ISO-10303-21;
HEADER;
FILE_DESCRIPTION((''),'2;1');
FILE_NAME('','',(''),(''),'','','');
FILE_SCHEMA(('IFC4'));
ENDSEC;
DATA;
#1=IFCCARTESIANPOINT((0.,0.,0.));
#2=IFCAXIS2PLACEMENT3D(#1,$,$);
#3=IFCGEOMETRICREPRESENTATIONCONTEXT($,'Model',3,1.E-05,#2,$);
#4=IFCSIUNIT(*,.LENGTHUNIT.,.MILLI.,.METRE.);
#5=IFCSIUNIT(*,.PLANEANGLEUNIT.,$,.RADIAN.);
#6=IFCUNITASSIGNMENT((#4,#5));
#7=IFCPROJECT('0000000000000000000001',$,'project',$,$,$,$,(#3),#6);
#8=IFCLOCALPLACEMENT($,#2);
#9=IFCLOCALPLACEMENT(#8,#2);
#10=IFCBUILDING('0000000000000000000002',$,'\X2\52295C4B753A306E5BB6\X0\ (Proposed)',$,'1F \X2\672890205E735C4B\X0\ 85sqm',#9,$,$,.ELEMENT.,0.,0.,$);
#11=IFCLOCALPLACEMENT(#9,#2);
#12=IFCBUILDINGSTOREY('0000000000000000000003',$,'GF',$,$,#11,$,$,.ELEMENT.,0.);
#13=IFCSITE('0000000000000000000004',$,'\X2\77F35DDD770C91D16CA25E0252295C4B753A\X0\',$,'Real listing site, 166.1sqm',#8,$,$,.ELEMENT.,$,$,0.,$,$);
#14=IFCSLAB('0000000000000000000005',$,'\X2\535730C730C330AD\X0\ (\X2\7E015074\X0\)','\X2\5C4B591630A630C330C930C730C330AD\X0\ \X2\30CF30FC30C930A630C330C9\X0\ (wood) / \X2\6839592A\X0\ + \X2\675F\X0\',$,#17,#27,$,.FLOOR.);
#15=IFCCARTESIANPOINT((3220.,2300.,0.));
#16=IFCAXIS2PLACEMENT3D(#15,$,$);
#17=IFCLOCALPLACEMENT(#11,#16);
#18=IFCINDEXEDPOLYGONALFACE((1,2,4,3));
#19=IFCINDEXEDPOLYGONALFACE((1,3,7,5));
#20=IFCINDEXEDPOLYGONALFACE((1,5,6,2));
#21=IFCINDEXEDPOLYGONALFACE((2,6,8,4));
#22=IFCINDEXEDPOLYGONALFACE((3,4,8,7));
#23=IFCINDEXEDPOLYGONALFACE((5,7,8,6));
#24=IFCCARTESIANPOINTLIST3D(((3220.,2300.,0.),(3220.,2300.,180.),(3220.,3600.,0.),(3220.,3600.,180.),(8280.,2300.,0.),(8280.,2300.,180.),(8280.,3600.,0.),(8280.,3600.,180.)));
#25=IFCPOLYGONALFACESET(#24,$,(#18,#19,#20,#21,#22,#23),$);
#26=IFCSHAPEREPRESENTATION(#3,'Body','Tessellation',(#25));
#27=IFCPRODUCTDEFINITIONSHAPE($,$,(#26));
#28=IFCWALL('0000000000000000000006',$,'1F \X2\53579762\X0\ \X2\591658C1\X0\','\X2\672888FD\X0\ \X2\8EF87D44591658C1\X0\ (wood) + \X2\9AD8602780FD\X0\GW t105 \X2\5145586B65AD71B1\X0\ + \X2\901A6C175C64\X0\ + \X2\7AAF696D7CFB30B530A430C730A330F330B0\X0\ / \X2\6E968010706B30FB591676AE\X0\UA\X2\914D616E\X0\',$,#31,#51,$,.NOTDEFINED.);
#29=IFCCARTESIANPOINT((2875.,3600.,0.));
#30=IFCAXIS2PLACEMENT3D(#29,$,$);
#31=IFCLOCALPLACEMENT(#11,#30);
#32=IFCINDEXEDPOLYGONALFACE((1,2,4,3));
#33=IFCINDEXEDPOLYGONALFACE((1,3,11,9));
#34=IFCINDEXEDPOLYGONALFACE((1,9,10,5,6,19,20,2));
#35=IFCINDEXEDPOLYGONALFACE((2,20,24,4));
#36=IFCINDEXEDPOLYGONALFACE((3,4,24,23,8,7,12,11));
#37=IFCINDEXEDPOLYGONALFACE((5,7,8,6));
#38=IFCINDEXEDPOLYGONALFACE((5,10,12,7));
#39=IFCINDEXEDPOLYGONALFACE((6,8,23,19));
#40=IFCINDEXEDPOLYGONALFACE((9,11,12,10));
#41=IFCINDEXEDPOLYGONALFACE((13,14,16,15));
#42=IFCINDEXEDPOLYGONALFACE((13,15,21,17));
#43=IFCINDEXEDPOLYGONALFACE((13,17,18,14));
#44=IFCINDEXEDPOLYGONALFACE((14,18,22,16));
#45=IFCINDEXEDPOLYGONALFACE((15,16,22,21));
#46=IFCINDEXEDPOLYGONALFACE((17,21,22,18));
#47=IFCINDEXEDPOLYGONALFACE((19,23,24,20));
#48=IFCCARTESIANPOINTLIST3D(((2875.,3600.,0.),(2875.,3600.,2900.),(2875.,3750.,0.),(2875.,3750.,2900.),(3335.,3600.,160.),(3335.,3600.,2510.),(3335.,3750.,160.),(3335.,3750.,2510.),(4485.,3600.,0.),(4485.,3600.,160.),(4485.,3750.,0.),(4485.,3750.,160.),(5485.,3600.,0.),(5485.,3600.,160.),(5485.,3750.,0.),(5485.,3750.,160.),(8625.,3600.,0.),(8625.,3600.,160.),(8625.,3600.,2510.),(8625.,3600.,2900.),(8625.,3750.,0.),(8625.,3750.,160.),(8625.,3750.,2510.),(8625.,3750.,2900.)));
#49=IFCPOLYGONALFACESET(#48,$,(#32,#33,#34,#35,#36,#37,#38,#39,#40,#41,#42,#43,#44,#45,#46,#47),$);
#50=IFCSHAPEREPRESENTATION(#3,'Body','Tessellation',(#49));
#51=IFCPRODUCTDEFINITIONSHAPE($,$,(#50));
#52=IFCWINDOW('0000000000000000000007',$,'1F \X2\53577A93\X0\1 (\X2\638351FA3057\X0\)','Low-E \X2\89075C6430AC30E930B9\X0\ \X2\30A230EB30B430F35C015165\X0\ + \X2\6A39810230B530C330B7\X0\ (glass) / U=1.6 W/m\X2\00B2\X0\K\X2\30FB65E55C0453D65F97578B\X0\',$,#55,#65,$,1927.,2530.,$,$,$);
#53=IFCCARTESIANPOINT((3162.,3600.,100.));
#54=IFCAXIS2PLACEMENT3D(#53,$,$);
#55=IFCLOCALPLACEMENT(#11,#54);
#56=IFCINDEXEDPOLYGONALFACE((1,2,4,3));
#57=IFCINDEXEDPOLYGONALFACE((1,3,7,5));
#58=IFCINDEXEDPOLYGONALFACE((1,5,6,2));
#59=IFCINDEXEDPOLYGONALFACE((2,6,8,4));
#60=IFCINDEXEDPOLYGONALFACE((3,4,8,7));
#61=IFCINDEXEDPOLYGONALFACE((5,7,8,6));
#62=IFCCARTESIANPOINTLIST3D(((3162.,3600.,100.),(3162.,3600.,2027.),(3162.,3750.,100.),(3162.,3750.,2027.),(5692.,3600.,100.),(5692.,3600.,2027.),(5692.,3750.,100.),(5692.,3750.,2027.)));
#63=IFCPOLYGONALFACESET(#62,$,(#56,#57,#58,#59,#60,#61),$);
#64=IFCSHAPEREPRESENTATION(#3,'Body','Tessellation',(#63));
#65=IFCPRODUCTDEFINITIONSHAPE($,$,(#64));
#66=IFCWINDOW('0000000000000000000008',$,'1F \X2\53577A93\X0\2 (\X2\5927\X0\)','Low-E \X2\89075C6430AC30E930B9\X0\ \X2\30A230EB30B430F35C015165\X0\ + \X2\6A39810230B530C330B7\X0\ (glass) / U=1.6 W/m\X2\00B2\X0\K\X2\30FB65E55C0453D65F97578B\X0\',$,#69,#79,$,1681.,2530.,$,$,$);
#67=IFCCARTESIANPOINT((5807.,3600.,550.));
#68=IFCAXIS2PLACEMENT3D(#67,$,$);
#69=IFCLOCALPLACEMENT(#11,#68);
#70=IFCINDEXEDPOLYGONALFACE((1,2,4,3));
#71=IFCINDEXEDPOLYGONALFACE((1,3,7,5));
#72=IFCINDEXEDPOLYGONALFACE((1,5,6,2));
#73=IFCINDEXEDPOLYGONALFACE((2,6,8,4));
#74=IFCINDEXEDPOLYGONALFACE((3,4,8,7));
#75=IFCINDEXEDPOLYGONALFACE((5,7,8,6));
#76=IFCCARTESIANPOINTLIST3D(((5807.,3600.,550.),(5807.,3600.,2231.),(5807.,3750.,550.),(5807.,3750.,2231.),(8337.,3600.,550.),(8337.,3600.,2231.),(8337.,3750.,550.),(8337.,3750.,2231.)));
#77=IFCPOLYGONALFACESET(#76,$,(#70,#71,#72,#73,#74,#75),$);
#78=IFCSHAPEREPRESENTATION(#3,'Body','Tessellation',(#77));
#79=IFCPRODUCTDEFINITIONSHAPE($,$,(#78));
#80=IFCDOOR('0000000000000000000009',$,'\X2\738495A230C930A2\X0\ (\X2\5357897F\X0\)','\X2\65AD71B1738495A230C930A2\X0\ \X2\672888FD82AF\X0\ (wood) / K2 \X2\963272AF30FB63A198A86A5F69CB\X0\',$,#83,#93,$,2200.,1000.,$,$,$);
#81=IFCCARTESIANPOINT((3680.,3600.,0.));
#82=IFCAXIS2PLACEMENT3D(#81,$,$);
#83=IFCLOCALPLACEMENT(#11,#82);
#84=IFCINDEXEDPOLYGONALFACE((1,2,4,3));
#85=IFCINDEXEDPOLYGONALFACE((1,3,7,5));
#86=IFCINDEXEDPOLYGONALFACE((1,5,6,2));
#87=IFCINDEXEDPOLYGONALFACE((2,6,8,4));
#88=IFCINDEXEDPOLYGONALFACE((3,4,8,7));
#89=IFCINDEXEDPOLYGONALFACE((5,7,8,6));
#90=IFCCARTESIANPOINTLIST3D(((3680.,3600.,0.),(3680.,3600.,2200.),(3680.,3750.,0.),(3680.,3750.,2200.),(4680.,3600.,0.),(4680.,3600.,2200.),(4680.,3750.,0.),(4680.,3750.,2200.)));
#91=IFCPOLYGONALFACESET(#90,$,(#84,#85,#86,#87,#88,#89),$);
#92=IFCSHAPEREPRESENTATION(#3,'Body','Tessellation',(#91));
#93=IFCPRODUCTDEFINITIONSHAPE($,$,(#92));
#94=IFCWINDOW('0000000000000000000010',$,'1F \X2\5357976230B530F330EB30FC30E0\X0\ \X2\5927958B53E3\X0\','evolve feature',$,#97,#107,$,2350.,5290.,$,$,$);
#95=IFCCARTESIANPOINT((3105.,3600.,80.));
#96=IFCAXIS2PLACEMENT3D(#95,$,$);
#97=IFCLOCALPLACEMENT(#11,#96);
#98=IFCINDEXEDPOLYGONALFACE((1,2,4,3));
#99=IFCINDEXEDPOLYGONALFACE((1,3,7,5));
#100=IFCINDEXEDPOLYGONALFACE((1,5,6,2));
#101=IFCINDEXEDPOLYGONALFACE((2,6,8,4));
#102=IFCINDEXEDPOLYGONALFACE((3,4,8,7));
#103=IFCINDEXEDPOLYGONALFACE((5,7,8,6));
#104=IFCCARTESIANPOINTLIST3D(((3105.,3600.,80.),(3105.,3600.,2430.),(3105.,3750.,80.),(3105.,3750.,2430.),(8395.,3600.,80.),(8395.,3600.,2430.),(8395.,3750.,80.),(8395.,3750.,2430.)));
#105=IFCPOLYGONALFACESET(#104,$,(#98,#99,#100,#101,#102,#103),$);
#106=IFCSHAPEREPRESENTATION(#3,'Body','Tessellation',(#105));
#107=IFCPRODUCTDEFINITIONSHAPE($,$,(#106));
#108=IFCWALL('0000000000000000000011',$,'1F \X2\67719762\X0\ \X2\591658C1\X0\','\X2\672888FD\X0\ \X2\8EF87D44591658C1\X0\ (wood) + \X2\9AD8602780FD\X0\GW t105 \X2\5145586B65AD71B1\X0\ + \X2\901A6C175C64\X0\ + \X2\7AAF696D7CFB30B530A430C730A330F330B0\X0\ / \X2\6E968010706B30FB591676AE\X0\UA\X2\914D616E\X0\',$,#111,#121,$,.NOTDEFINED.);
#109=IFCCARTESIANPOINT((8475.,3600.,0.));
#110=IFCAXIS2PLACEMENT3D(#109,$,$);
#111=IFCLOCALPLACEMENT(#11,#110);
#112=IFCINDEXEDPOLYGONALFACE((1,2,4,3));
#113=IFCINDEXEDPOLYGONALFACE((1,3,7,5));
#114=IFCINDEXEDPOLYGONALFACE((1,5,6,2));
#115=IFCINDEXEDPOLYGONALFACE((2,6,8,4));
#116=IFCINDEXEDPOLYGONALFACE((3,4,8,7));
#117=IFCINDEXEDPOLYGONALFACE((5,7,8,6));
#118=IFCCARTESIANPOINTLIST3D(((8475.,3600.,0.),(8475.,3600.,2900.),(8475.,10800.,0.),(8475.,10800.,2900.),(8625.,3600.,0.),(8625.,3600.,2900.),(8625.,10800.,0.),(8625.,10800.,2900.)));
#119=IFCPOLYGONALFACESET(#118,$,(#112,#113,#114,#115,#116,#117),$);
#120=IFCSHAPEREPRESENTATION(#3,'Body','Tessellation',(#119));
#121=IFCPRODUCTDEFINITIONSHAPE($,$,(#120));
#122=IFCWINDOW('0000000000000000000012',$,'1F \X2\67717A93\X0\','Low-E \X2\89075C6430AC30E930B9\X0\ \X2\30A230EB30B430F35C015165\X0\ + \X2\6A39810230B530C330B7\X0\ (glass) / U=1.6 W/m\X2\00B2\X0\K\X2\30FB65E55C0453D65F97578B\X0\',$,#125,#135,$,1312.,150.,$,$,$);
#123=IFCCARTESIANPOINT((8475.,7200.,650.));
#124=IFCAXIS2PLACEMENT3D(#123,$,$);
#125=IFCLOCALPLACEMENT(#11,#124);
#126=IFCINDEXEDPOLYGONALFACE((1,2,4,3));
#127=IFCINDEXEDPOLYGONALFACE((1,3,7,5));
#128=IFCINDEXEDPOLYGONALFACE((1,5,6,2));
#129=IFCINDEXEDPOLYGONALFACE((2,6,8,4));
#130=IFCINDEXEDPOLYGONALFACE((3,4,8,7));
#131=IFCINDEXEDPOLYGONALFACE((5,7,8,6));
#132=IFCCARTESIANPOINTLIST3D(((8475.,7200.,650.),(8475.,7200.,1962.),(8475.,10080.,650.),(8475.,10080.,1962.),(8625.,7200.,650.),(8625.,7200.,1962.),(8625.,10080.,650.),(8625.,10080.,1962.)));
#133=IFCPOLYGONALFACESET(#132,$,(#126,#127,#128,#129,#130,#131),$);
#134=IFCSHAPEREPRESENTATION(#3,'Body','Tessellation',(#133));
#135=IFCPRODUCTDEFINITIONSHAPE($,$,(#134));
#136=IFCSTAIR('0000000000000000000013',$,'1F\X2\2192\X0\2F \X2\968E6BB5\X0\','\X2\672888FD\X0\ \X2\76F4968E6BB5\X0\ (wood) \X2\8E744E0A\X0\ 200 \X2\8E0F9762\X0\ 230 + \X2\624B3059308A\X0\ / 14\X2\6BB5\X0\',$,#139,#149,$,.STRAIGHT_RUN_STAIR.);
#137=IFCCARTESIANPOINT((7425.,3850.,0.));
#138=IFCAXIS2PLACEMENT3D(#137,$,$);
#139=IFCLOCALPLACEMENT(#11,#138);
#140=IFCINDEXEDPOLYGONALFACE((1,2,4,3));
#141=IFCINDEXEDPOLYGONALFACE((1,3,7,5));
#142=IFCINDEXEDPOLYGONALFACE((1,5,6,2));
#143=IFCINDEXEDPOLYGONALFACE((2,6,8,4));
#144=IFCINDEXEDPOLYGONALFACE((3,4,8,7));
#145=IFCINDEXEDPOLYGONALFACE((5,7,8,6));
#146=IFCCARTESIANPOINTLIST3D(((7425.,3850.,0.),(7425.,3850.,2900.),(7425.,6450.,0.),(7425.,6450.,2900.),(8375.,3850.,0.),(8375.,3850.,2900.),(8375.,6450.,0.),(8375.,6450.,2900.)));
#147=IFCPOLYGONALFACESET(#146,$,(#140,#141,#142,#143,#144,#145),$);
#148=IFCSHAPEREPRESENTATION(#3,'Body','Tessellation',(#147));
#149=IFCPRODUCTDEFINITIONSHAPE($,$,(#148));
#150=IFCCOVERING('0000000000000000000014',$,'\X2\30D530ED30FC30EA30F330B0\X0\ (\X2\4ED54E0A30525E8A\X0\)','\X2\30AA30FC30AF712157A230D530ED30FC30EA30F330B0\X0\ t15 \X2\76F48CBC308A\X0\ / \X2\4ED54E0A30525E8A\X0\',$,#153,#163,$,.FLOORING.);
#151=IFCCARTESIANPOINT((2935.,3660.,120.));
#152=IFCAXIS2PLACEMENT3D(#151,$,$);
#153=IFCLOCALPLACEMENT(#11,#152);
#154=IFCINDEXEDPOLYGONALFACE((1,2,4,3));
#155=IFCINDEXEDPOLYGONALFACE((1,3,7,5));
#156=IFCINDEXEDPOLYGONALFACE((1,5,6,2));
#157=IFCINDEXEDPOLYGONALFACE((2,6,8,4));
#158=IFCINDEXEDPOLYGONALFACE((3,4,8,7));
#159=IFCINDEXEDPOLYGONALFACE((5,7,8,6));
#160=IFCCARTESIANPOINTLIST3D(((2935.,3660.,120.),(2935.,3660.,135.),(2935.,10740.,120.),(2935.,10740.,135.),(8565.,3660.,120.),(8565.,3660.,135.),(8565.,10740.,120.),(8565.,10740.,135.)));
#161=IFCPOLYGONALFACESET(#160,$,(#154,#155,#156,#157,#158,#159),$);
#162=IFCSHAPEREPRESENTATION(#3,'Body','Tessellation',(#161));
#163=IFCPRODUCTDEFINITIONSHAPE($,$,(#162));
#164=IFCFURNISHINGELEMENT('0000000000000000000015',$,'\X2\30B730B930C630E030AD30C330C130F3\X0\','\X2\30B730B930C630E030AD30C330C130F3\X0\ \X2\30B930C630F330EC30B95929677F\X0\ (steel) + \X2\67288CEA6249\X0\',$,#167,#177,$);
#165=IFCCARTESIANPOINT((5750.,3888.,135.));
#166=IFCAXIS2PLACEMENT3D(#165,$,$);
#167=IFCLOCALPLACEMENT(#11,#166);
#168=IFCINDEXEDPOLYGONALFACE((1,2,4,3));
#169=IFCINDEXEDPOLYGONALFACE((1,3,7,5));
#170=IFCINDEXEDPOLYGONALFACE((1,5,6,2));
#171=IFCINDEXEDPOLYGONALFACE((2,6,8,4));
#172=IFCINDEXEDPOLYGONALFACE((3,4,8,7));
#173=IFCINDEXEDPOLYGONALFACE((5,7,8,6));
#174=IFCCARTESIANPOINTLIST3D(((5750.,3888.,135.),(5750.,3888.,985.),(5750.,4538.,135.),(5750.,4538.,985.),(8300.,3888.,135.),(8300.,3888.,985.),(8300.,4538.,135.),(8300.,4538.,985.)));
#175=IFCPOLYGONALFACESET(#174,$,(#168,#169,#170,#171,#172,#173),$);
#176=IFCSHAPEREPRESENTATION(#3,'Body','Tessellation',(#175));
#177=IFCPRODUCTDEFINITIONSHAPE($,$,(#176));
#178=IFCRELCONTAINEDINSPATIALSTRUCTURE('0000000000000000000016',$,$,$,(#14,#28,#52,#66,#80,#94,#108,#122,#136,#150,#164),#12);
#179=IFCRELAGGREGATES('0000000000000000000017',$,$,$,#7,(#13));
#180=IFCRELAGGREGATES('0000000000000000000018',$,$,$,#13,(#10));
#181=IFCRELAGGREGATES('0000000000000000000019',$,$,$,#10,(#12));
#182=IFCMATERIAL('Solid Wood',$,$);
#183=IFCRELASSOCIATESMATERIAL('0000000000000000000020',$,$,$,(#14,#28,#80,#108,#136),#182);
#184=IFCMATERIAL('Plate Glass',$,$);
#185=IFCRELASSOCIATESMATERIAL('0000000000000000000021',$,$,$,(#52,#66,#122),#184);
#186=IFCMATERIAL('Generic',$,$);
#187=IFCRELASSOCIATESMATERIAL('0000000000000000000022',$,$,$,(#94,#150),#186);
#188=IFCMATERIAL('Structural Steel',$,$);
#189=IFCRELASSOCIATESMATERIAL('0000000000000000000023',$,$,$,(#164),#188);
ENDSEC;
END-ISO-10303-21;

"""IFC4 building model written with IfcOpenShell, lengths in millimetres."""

from ifc_helpers import new_model, si_unit, frame, frame_2d, origin, place, context, project, spatial, rectangle, extrude, material, element, fill, save


model = new_model("IFC4")

# Units and contexts
model_context = context("Model", 3, precision=1e-05, world=origin())
ifc_project = project(units=[si_unit("LENGTHUNIT", "METRE", prefix="MILLI"), si_unit("PLANEANGLEUNIT", "RADIAN")], contexts=[model_context])

# Site, building, storey
site_placement = place(None, origin())
site = spatial("IfcSite", under=ifc_project, at=site_placement, Name="石川県金沢市利屋町", ObjectType="Real listing site, 166.1sqm", CompositionType="ELEMENT", RefElevation=0.0)
building_placement = place(site_placement, origin())
building = spatial("IfcBuilding", under=site, at=building_placement, Name="利屋町の家 (Proposed)", ObjectType="1F 木造平屋 85sqm", CompositionType="ELEMENT", ElevationOfRefHeight=0.0, ElevationOfTerrain=0.0)
storey_placement = place(building_placement, origin())
storey = spatial("IfcBuildingStorey", under=building, at=storey_placement, Name="GF", CompositionType="ELEMENT", Elevation=0.0)

# Slab
ifc_material_1 = material(Name="Solid Wood")
slab_1_placement = place(storey_placement, frame((3220.0, 2300.0, 0.0)))
element("IfcSlab", 1, at=slab_1_placement, inside=storey, material=ifc_material_1, Name="南デッキ (縁側)", Description="屋外ウッドデッキ ハードウッド (wood) / 根太 + 束", PredefinedType="FLOOR", context=model_context, shape_type="SweptSolid", body=[
    extrude(rectangle(XDim=5060.0, YDim=1300.0, at=frame_2d((2530.0, 650.0))), frame((3220.0, 2300.0, 0.0)), (0.0, 0.0, 1.0), 180.0),
])
ifc_material_2 = material(Name="Generic")

# Wall, openings, windows, door
wall_1_placement = place(storey_placement, frame((2875.0, 3600.0, 0.0)))
wall_1 = element("IfcWall", 2, at=wall_1_placement, inside=storey, material=ifc_material_1, Name="1F 南面 外壁", Description="木製 軸組外壁 (wood) + 高性能GW t105 充填断熱 + 通気層 + 窯業系サイディング / 準耐火・外皮UA配慮", PredefinedType="NOTDEFINED", context=model_context, shape_type="SweptSolid", body=[
    extrude(rectangle(XDim=5750.0, YDim=150.0, at=frame_2d((2875.0, 75.0))), frame((2875.0, 3600.0, 0.0)), (0.0, 0.0, 1.0), 2900.0),
])
opening_1_placement = place(storey_placement, frame((3162.0, 3600.0, 100.0)))
opening_1 = element("IfcOpeningElement", 3, at=opening_1_placement, cuts=wall_1, PredefinedType="NOTDEFINED", context=model_context, shape_type="SweptSolid", body=[
    extrude(rectangle(XDim=2530.0, YDim=150.0, at=frame_2d((1265.0, 75.0))), frame((3162.0, 3600.0, 100.0)), (0.0, 0.0, 1.0), 1927.0),
])
opening_2_placement = place(storey_placement, frame((5807.0, 3600.0, 550.0)))
opening_2 = element("IfcOpeningElement", 4, at=opening_2_placement, cuts=wall_1, PredefinedType="NOTDEFINED", context=model_context, shape_type="SweptSolid", body=[
    extrude(rectangle(XDim=2530.0, YDim=150.0, at=frame_2d((1265.0, 75.0))), frame((5807.0, 3600.0, 550.0)), (0.0, 0.0, 1.0), 1681.0),
])
opening_3_placement = place(storey_placement, frame((3680.0, 3600.0, 0.0)))
opening_3 = element("IfcOpeningElement", 5, at=opening_3_placement, cuts=wall_1, PredefinedType="NOTDEFINED", context=model_context, shape_type="SweptSolid", body=[
    extrude(rectangle(XDim=1000.0, YDim=150.0, at=frame_2d((500.0, 75.0))), frame((3680.0, 3600.0, 0.0)), (0.0, 0.0, 1.0), 2200.0),
])
opening_4_placement = place(storey_placement, frame((3105.0, 3600.0, 80.0)))
opening_4 = element("IfcOpeningElement", 6, at=opening_4_placement, cuts=wall_1, PredefinedType="NOTDEFINED", context=model_context, shape_type="SweptSolid", body=[
    extrude(rectangle(XDim=5290.0, YDim=150.0, at=frame_2d((2645.0, 75.0))), frame((3105.0, 3600.0, 80.0)), (0.0, 0.0, 1.0), 2350.0),
])
ifc_material_3 = material(Name="Plate Glass")
window_1_placement = place(storey_placement, frame((3162.0, 3600.0, 100.0)))
window_1 = element("IfcWindow", 7, at=window_1_placement, inside=storey, material=ifc_material_3, Name="1F 南窓1 (掃出し)", Description="Low-E 複層ガラス アルゴン封入 + 樹脂サッシ (glass) / U=1.6 W/m²K・日射取得型", OverallHeight=1927.0, OverallWidth=2530.0, context=model_context, shape_type="SweptSolid", body=[
    extrude(rectangle(XDim=2530.0, YDim=150.0, at=frame_2d((1265.0, 75.0))), frame((3162.0, 3600.0, 100.0)), (0.0, 0.0, 1.0), 1927.0),
])
fill(opening_1, window_1)
window_2_placement = place(storey_placement, frame((5807.0, 3600.0, 550.0)))
window_2 = element("IfcWindow", 8, at=window_2_placement, inside=storey, material=ifc_material_3, Name="1F 南窓2 (大)", Description="Low-E 複層ガラス アルゴン封入 + 樹脂サッシ (glass) / U=1.6 W/m²K・日射取得型", OverallHeight=1681.0, OverallWidth=2530.0, context=model_context, shape_type="SweptSolid", body=[
    extrude(rectangle(XDim=2530.0, YDim=150.0, at=frame_2d((1265.0, 75.0))), frame((5807.0, 3600.0, 550.0)), (0.0, 0.0, 1.0), 1681.0),
])
fill(opening_2, window_2)
door_placement = place(storey_placement, frame((3680.0, 3600.0, 0.0)))
door = element("IfcDoor", 9, at=door_placement, inside=storey, material=ifc_material_1, Name="玄関ドア (南西)", Description="断熱玄関ドア 木製芯 (wood) / K2 防犯・採風機構", OverallHeight=2200.0, OverallWidth=1000.0, context=model_context, shape_type="SweptSolid", body=[
    extrude(rectangle(XDim=1000.0, YDim=150.0, at=frame_2d((500.0, 75.0))), frame((3680.0, 3600.0, 0.0)), (0.0, 0.0, 1.0), 2200.0),
])
fill(opening_3, door)
window_3_placement = place(storey_placement, frame((3105.0, 3600.0, 80.0)))
window_3 = element("IfcWindow", 10, at=window_3_placement, inside=storey, material=ifc_material_2, Name="1F 南面サンルーム 大開口", Description="evolve feature", OverallHeight=2350.0, OverallWidth=5290.0, context=model_context, shape_type="SweptSolid", body=[
    extrude(rectangle(XDim=5290.0, YDim=150.0, at=frame_2d((2645.0, 75.0))), frame((3105.0, 3600.0, 80.0)), (0.0, 0.0, 1.0), 2350.0),
])
fill(opening_4, window_3)

# Wall, opening, window
wall_2_placement = place(storey_placement, frame((8475.0, 3600.0, 0.0)))
wall_2 = element("IfcWall", 11, at=wall_2_placement, inside=storey, material=ifc_material_1, Name="1F 東面 外壁", Description="木製 軸組外壁 (wood) + 高性能GW t105 充填断熱 + 通気層 + 窯業系サイディング / 準耐火・外皮UA配慮", PredefinedType="NOTDEFINED", context=model_context, shape_type="SweptSolid", body=[
    extrude(rectangle(XDim=150.0, YDim=7200.0, at=frame_2d((75.0, 3600.0))), frame((8475.0, 3600.0, 0.0)), (0.0, 0.0, 1.0), 2900.0),
])
opening_5_placement = place(storey_placement, frame((8475.0, 7200.0, 650.0)))
opening_5 = element("IfcOpeningElement", 12, at=opening_5_placement, cuts=wall_2, PredefinedType="NOTDEFINED", context=model_context, shape_type="SweptSolid", body=[
    extrude(rectangle(XDim=150.0, YDim=2880.0, at=frame_2d((75.0, 1440.0))), frame((8475.0, 7200.0, 650.0)), (0.0, 0.0, 1.0), 1312.0),
])
window_4_placement = place(storey_placement, frame((8475.0, 7200.0, 650.0)))
window_4 = element("IfcWindow", 13, at=window_4_placement, inside=storey, material=ifc_material_3, Name="1F 東窓", Description="Low-E 複層ガラス アルゴン封入 + 樹脂サッシ (glass) / U=1.6 W/m²K・日射取得型", OverallHeight=1312.0, OverallWidth=150.0, context=model_context, shape_type="SweptSolid", body=[
    extrude(rectangle(XDim=150.0, YDim=2880.0, at=frame_2d((75.0, 1440.0))), frame((8475.0, 7200.0, 650.0)), (0.0, 0.0, 1.0), 1312.0),
])
fill(opening_5, window_4)

# Stair
stair_placement = place(storey_placement, frame((7425.0, 3850.0, 0.0)))
element("IfcStair", 14, at=stair_placement, inside=storey, material=ifc_material_1, Name="1F→2F 階段", Description="木製 直階段 (wood) 蹴上 200 踏面 230 + 手すり / 14段", PredefinedType="STRAIGHT_RUN_STAIR", context=model_context, shape_type="SweptSolid", body=[
    extrude(rectangle(XDim=950.0, YDim=2600.0, at=frame_2d((475.0, 1300.0))), frame((7425.0, 3850.0, 0.0)), (0.0, 0.0, 1.0), 2900.0),
])

# Covering
covering_placement = place(storey_placement, frame((2935.0, 3660.0, 120.0)))
element("IfcCovering", 15, at=covering_placement, inside=storey, material=ifc_material_2, Name="フローリング (仕上げ床)", Description="オーク無垢フローリング t15 直貼り / 仕上げ床", PredefinedType="FLOORING", context=model_context, shape_type="SweptSolid", body=[
    extrude(rectangle(XDim=5630.0, YDim=7080.0, at=frame_2d((2815.0, 3540.0))), frame((2935.0, 3660.0, 120.0)), (0.0, 0.0, 1.0), 15.0),
])

# Furnishing element
ifc_material_4 = material(Name="Structural Steel")
furnishing_placement = place(storey_placement, frame((5750.0, 3888.0, 135.0)))
element("IfcFurnishingElement", 16, at=furnishing_placement, inside=storey, material=ifc_material_4, Name="システムキッチン", Description="システムキッチン ステンレス天板 (steel) + 木質扉", context=model_context, shape_type="SweptSolid", body=[
    extrude(rectangle(XDim=2550.0, YDim=650.0, at=frame_2d((1275.0, 325.0))), frame((5750.0, 3888.0, 135.0)), (0.0, 0.0, 1.0), 850.0),
])

save(model, "model.ifc")
